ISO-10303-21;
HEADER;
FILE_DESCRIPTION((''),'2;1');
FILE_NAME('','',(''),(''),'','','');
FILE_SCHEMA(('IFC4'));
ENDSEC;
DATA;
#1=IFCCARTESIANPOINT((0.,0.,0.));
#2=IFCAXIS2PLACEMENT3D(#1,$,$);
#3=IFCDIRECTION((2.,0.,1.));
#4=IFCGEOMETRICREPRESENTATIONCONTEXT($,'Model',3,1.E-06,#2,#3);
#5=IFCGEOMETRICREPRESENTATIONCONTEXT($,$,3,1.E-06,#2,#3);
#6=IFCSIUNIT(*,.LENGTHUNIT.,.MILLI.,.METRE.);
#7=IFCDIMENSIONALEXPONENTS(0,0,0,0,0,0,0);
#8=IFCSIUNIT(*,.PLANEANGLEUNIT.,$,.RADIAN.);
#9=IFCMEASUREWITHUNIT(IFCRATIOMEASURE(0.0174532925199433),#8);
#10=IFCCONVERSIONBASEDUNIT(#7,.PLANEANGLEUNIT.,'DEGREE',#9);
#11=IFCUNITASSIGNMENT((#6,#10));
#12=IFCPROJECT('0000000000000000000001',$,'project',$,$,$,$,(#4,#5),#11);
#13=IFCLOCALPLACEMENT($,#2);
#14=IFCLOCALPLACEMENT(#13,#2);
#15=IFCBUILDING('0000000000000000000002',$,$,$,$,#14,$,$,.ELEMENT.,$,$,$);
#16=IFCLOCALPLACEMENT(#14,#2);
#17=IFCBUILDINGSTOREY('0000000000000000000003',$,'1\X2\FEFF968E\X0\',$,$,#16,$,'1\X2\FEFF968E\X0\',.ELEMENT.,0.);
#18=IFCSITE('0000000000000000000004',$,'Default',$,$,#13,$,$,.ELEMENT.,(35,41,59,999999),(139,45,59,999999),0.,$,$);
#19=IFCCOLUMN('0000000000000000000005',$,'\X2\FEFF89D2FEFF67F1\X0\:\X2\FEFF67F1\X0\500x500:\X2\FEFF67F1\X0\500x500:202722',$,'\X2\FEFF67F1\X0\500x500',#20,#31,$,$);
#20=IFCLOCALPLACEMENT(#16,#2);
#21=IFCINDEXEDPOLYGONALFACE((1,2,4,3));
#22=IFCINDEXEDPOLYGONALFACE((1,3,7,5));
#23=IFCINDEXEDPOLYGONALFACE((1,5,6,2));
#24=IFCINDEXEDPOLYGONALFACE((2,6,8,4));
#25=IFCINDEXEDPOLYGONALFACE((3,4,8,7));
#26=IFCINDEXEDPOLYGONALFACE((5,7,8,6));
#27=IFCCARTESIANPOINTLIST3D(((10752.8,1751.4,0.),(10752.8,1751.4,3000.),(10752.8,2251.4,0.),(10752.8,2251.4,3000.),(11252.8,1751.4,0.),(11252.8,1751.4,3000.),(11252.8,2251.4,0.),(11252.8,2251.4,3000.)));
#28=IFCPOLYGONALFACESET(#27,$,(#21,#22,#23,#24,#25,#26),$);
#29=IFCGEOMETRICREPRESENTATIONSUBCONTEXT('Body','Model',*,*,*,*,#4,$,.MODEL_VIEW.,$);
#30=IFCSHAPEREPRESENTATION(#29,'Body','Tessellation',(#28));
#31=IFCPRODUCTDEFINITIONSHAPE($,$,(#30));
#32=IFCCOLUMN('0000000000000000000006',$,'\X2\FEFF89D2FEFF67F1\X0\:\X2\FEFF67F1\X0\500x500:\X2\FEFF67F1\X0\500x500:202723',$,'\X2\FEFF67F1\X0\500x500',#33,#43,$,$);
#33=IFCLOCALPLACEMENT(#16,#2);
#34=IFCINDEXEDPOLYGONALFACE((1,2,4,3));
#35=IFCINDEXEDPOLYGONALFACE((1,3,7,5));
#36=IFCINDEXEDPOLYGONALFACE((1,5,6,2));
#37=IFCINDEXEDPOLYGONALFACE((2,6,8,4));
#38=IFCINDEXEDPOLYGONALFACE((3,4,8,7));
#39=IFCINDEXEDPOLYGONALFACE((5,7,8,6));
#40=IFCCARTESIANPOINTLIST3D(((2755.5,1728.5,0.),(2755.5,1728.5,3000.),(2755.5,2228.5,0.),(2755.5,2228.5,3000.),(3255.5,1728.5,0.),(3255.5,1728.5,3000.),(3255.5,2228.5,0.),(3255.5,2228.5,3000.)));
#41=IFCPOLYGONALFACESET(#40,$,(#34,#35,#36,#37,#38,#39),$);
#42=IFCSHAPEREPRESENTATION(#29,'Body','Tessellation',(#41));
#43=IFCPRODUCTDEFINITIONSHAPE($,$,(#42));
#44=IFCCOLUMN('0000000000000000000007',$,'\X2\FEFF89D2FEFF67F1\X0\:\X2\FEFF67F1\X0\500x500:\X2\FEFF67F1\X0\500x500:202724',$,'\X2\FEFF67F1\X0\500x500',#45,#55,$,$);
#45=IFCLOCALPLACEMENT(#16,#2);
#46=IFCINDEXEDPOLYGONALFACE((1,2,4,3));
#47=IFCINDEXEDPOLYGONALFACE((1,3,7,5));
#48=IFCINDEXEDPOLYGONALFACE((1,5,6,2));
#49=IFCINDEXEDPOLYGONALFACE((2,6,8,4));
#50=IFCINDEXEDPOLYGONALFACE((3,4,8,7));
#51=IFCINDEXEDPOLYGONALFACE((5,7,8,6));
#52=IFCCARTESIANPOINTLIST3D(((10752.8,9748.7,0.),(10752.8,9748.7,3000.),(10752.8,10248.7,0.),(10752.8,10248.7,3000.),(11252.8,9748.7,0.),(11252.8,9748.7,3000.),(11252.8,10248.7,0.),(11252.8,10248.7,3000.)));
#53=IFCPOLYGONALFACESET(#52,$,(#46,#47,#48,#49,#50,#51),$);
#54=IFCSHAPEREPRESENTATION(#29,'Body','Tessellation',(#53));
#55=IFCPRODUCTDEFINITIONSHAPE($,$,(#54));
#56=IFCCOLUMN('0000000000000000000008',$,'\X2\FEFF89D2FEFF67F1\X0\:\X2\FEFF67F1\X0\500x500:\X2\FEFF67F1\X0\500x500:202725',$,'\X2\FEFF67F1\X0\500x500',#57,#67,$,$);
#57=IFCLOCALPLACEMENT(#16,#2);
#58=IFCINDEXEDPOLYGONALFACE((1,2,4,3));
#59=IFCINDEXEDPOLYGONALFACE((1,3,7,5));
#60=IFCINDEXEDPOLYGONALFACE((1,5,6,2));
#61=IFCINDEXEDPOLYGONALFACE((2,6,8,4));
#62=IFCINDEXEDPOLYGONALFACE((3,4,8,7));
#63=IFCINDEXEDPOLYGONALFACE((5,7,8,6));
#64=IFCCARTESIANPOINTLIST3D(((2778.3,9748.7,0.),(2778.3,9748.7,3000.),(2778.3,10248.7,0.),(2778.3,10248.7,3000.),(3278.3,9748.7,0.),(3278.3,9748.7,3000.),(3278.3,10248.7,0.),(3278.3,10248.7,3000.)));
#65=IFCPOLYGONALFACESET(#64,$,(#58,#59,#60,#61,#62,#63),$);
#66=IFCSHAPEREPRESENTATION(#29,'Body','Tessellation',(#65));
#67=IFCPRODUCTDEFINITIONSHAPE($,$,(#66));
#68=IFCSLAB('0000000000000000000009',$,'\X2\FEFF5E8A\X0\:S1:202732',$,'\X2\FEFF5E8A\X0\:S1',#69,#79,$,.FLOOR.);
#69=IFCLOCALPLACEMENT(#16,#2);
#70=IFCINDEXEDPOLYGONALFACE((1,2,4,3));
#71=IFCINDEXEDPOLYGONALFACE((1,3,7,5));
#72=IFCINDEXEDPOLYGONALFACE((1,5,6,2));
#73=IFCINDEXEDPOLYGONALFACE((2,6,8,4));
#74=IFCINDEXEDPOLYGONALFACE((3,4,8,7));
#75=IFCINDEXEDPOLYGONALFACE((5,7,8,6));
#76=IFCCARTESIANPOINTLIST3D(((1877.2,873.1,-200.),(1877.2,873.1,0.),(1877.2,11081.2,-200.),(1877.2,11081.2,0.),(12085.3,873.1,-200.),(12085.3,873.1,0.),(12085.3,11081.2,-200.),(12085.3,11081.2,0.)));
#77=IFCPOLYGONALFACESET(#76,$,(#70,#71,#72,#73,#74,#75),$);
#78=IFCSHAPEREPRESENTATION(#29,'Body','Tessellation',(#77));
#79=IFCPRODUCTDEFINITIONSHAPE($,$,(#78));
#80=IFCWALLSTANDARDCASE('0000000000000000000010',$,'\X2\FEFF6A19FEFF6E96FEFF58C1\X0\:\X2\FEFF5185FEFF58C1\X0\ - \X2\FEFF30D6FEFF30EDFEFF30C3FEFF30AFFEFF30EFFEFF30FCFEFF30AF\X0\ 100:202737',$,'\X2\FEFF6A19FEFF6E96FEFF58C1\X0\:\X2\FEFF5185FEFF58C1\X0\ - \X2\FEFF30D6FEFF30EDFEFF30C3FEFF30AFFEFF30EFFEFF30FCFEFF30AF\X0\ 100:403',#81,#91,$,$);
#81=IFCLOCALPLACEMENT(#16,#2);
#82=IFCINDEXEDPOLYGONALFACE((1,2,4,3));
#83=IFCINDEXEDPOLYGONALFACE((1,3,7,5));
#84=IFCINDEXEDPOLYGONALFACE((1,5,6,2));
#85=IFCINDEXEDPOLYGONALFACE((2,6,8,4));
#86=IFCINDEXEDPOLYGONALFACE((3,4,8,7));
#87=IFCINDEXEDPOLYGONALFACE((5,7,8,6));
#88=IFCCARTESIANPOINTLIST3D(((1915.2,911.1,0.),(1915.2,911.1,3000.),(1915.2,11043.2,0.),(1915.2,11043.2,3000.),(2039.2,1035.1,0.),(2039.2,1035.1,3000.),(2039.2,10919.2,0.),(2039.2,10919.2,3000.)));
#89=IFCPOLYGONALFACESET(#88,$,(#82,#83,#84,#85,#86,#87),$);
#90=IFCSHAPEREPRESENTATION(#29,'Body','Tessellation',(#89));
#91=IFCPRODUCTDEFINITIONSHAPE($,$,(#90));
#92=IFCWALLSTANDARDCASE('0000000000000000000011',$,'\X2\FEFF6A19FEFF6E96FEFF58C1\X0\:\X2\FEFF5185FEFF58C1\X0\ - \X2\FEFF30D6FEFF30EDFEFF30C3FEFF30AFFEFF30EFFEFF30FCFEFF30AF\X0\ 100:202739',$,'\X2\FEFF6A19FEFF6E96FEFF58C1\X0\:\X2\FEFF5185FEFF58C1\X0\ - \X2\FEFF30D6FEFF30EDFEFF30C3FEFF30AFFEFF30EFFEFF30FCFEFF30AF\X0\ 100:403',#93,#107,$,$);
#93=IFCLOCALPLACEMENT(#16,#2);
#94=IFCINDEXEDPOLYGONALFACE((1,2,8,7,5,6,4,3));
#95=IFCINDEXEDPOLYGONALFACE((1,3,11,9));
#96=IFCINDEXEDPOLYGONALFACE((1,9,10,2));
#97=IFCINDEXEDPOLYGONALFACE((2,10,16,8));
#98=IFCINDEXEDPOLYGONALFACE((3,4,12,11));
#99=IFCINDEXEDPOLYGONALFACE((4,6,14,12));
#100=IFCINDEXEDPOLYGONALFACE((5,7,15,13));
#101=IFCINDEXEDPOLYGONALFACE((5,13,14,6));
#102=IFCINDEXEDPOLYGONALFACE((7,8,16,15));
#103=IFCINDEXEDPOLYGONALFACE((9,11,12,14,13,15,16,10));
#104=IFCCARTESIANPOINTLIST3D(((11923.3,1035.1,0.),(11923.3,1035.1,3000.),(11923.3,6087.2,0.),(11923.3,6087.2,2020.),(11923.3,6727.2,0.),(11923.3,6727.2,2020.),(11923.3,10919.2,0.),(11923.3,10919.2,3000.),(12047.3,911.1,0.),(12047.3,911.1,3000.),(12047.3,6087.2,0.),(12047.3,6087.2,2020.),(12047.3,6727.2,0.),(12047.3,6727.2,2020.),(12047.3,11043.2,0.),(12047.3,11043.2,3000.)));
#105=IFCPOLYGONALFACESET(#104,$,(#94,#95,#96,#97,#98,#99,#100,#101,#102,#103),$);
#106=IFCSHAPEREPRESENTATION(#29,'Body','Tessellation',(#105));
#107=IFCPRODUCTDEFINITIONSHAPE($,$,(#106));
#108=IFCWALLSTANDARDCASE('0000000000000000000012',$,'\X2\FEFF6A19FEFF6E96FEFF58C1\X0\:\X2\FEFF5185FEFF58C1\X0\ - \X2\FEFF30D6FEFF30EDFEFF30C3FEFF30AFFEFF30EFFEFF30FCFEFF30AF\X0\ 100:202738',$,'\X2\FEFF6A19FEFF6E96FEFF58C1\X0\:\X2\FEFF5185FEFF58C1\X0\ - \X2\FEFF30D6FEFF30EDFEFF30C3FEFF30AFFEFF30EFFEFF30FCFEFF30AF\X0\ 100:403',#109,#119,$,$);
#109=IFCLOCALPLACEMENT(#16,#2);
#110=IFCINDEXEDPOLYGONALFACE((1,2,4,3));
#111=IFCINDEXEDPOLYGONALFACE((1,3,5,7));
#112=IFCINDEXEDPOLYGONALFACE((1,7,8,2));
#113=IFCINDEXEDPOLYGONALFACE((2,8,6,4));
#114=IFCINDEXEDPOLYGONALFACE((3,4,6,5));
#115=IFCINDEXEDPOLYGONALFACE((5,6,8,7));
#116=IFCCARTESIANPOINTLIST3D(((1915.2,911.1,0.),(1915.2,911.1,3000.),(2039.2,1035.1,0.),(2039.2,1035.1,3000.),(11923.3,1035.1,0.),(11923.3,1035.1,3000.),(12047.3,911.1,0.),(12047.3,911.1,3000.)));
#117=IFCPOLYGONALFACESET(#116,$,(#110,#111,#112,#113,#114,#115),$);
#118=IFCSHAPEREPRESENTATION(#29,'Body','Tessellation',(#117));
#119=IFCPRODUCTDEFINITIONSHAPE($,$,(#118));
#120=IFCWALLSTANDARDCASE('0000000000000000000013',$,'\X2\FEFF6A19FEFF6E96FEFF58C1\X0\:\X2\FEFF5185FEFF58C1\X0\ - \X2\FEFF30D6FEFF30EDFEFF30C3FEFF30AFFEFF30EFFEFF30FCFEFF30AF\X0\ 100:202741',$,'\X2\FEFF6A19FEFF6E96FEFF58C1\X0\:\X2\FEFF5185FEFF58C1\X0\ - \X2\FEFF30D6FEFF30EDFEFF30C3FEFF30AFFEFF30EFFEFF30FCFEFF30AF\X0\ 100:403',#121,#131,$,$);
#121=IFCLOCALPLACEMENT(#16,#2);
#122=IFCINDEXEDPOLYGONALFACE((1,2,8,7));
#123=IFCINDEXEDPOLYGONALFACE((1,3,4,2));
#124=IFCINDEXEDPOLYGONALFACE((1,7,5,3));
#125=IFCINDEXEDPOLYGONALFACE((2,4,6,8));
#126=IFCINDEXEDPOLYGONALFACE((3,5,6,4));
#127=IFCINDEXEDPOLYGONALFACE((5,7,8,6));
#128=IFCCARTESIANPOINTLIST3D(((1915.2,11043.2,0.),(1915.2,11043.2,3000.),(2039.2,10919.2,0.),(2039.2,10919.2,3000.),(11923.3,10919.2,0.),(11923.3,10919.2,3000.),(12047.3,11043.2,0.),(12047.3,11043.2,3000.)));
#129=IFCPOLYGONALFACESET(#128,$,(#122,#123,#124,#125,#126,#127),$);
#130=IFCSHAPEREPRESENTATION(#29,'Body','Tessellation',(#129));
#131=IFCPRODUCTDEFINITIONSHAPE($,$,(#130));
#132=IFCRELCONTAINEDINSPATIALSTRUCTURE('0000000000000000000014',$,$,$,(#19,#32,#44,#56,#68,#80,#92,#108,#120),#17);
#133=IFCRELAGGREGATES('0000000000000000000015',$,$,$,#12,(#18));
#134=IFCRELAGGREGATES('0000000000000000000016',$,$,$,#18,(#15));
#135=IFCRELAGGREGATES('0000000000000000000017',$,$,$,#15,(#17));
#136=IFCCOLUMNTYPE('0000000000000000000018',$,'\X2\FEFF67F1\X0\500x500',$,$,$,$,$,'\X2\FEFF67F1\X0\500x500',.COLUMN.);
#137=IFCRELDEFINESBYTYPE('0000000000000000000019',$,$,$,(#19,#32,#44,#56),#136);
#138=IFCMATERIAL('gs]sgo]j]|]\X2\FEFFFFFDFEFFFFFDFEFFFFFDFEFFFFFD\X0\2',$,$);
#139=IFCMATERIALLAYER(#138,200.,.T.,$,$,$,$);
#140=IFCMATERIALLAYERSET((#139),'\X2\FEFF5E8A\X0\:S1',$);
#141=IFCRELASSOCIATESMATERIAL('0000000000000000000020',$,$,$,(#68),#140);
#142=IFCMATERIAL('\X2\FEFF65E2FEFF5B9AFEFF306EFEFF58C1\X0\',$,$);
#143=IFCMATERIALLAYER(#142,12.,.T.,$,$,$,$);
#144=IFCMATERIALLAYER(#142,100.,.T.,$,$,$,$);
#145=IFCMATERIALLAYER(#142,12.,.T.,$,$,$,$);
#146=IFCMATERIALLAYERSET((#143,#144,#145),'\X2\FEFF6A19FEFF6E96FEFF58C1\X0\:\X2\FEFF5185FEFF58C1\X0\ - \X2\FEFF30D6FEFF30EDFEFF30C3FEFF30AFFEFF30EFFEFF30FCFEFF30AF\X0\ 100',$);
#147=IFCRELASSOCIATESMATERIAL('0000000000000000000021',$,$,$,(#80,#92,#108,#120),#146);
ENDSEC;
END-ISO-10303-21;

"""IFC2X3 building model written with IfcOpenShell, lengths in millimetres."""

from ifc_helpers import new_model, entity, si_unit, converted_unit, direction, frame, frame_2d, origin, place, context, subcontext, project, spatial, polyline, rectangle, outline, extrude, source, transform, mapped, material, layer, layer_set, layer_usage, type_object, type_shapes, element, save


model = new_model("IFC2X3")

# Units and contexts
model_context = context("Model", 3, precision=1e-06, world=origin(), true_north=direction((2.0, 0.0, 1.0)))
context_of_model = context(None, 3, precision=1e-06, world=origin(), true_north=direction((2.0, 0.0, 1.0)))
body_context = subcontext(model_context, "Body", "Model", "MODEL_VIEW")
ifc_project = project(units=[si_unit("LENGTHUNIT", "METRE", prefix="MILLI"), converted_unit("PLANEANGLEUNIT", "DEGREE", entity("IfcRatioMeasure", 0.0174532925199433), si_unit("PLANEANGLEUNIT", "RADIAN"), dimensions=[0, 0, 0, 0, 0, 0, 0])], contexts=[model_context, context_of_model])

# Site, building, storey
site_placement = place(None, origin())
site = spatial("IfcSite", under=ifc_project, at=site_placement, Name="Default", CompositionType="ELEMENT", RefLatitude=(35, 41, 59, 999999), RefLongitude=(139, 45, 59, 999999), RefElevation=0.0)
building_placement = place(site_placement, origin())
building = spatial("IfcBuilding", under=site, at=building_placement, CompositionType="ELEMENT")
storey_placement = place(building_placement, origin())
storey = spatial("IfcBuildingStorey", under=building, at=storey_placement, Name="1\ufeff階", LongName="1\ufeff階", CompositionType="ELEMENT", Elevation=0.0)

# Columns
column_type = type_object("IfcColumnType", Name="\ufeff柱500x500", ElementType="\ufeff柱500x500", PredefinedType="COLUMN")
shared_shape = source(origin(), body_context, "Body", "SweptSolid", [
    extrude(rectangle(XDim=500.0, YDim=500.0, at=frame_2d((0.0, 0.0), x_axis=(0.0, -1.0))), origin(), (0.0, 0.0, 1.0), 3000.0),
])
type_shapes(column_type, [shared_shape])
for number, where, name in (
    (1, (11002.8, 2001.4, 0.0), "\ufeff角\ufeff柱:\ufeff柱500x500:\ufeff柱500x500:202722"),
    (2, (3005.5, 1978.5, 0.0), "\ufeff角\ufeff柱:\ufeff柱500x500:\ufeff柱500x500:202723"),
    (3, (11002.8, 9998.7, 0.0), "\ufeff角\ufeff柱:\ufeff柱500x500:\ufeff柱500x500:202724"),
    (4, (3028.3, 9998.7, 0.0), "\ufeff角\ufeff柱:\ufeff柱500x500:\ufeff柱500x500:202725"),
):
    element("IfcColumn", number, at=place(storey_placement, frame(where)), inside=storey, type_object=column_type, Name=name, ObjectType="\ufeff柱500x500", context=body_context, shape_type="MappedRepresentation", body=[
        mapped(shared_shape, transform((0.0, 0.0, 0.0), scale=1.0)),
    ])

# Slab
ifc_material_1 = material(Name="gs]sgo]j]|]\ufeff�\ufeff�\ufeff�\ufeff�2")
ifc_layer_1 = layer(ifc_material_1, 200.0, ventilated=True)
ifc_layer_set_1 = layer_set([ifc_layer_1], Name="\ufeff床:S1")
ifc_layer_usage_1 = layer_usage(ifc_layer_set_1, "AXIS3", "POSITIVE", 0.0)
slab_placement = place(storey_placement, frame((1877.2, 873.1, -200.0)))
element("IfcSlab", 5, at=slab_placement, inside=storey, material=ifc_layer_usage_1, Name="\ufeff床:S1:202732", ObjectType="\ufeff床:S1", PredefinedType="FLOOR", context=body_context, shape_type="SweptSolid", body=[
    extrude(rectangle(XDim=10208.1, YDim=10208.1, at=frame_2d((0.0, 0.0), x_axis=(0.0, -1.0))), frame((5104.0, 5104.0, 200.0), z_axis=(0.0, 0.0, -1.0), x_axis=(-1.0, 0.0, 0.0)), (0.0, 0.0, 1.0), 200.0),
])

# Wall
ifc_material_2 = material(Name="\ufeff既\ufeff定\ufeffの\ufeff壁")
ifc_layer_2 = layer(ifc_material_2, 12.0, ventilated=True)
ifc_layer_3 = layer(ifc_material_2, 100.0, ventilated=True)
ifc_layer_4 = layer(ifc_material_2, 12.0, ventilated=True)
ifc_layer_set_2 = layer_set([ifc_layer_2, ifc_layer_3, ifc_layer_4], Name="\ufeff標\ufeff準\ufeff壁:\ufeff内\ufeff壁 - \ufeffブ\ufeffロ\ufeffッ\ufeffク\ufeffワ\ufeffー\ufeffク 100")
ifc_layer_usage_2 = layer_usage(ifc_layer_set_2, "AXIS2", "NEGATIVE", 62.0)
wall_1_placement = place(storey_placement, frame((1977.2, 11043.2, 0.0), z_axis=(0.0, 0.0, 1.0), x_axis=(0.0, -1.0, 0.0)))
element("IfcWallStandardCase", 6, at=wall_1_placement, inside=storey, material=ifc_layer_usage_2, Name="\ufeff標\ufeff準\ufeff壁:\ufeff内\ufeff壁 - \ufeffブ\ufeffロ\ufeffッ\ufeffク\ufeffワ\ufeffー\ufeffク 100:202737", ObjectType="\ufeff標\ufeff準\ufeff壁:\ufeff内\ufeff壁 - \ufeffブ\ufeffロ\ufeffッ\ufeffク\ufeffワ\ufeffー\ufeffク 100:403", context=body_context, shape_type="SweptSolid", body=[
    extrude(outline(polyline([(10132.1, -62.0), (10008.1, 62.0), (124.0, 62.0), (0.0, -62.0), (10132.1, -62.0)])), origin(), (0.0, 0.0, 1.0), 3000.0),
])

# Wall, opening
ifc_layer_usage_3 = layer_usage(ifc_layer_set_2, "AXIS2", "NEGATIVE", 62.0)
wall_2_placement = place(storey_placement, frame((11985.3, 911.1, 0.0), z_axis=(0.0, 0.0, 1.0), x_axis=(0.0, 1.0, 0.0)))
wall_2 = element("IfcWallStandardCase", 7, at=wall_2_placement, inside=storey, material=ifc_layer_usage_3, Name="\ufeff標\ufeff準\ufeff壁:\ufeff内\ufeff壁 - \ufeffブ\ufeffロ\ufeffッ\ufeffク\ufeffワ\ufeffー\ufeffク 100:202739", ObjectType="\ufeff標\ufeff準\ufeff壁:\ufeff内\ufeff壁 - \ufeffブ\ufeffロ\ufeffッ\ufeffク\ufeffワ\ufeffー\ufeffク 100:403", context=body_context, shape_type="SweptSolid", body=[
    extrude(outline(polyline([(0.0, -62.0), (10132.1, -62.0), (10008.1, 62.0), (124.0, 62.0), (0.0, -62.0)])), origin(), (0.0, 0.0, 1.0), 3000.0),
])
opening_placement = place(wall_2_placement, frame((5816.1, 62.0, 0.0)))
element("IfcOpeningElement", 8, at=opening_placement, cuts=wall_2, ObjectType="Opening", context=body_context, shape_type="SweptSolid", body=[
    extrude(rectangle(XDim=2020.0, YDim=640.0, at=frame_2d((1010.0, 320.0), x_axis=(-1.0, 0.0))), frame((0.0, 0.0, 0.0), z_axis=(0.0, -1.0, 0.0), x_axis=(0.0, 0.0, 1.0)), (0.0, 0.0, 1.0), 124.0),
])

# Walls
ifc_layer_usage_4 = layer_usage(ifc_layer_set_2, "AXIS2", "NEGATIVE", 62.0)
wall_3_placement = place(storey_placement, frame((1915.2, 973.1, 0.0)))
element("IfcWallStandardCase", 9, at=wall_3_placement, inside=storey, material=ifc_layer_usage_4, Name="\ufeff標\ufeff準\ufeff壁:\ufeff内\ufeff壁 - \ufeffブ\ufeffロ\ufeffッ\ufeffク\ufeffワ\ufeffー\ufeffク 100:202738", ObjectType="\ufeff標\ufeff準\ufeff壁:\ufeff内\ufeff壁 - \ufeffブ\ufeffロ\ufeffッ\ufeffク\ufeffワ\ufeffー\ufeffク 100:403", context=body_context, shape_type="SweptSolid", body=[
    extrude(outline(polyline([(10132.1, -62.0), (10008.1, 62.0), (124.0, 62.0), (0.0, -62.0), (10132.1, -62.0)])), origin(), (0.0, 0.0, 1.0), 3000.0),
])
ifc_layer_usage_5 = layer_usage(ifc_layer_set_2, "AXIS2", "NEGATIVE", 62.0)
wall_4_placement = place(storey_placement, frame((12047.3, 10981.2, 0.0), z_axis=(0.0, 0.0, 1.0), x_axis=(-1.0, 0.0, 0.0)))
element("IfcWallStandardCase", 10, at=wall_4_placement, inside=storey, material=ifc_layer_usage_5, Name="\ufeff標\ufeff準\ufeff壁:\ufeff内\ufeff壁 - \ufeffブ\ufeffロ\ufeffッ\ufeffク\ufeffワ\ufeffー\ufeffク 100:202741", ObjectType="\ufeff標\ufeff準\ufeff壁:\ufeff内\ufeff壁 - \ufeffブ\ufeffロ\ufeffッ\ufeffク\ufeffワ\ufeffー\ufeffク 100:403", context=body_context, shape_type="SweptSolid", body=[
    extrude(outline(polyline([(10132.1, -62.0), (10008.1, 62.0), (124.0, 62.0), (0.0, -62.0), (10132.1, -62.0)])), origin(), (0.0, 0.0, 1.0), 3000.0),
])

save(model, "model.ifc")
